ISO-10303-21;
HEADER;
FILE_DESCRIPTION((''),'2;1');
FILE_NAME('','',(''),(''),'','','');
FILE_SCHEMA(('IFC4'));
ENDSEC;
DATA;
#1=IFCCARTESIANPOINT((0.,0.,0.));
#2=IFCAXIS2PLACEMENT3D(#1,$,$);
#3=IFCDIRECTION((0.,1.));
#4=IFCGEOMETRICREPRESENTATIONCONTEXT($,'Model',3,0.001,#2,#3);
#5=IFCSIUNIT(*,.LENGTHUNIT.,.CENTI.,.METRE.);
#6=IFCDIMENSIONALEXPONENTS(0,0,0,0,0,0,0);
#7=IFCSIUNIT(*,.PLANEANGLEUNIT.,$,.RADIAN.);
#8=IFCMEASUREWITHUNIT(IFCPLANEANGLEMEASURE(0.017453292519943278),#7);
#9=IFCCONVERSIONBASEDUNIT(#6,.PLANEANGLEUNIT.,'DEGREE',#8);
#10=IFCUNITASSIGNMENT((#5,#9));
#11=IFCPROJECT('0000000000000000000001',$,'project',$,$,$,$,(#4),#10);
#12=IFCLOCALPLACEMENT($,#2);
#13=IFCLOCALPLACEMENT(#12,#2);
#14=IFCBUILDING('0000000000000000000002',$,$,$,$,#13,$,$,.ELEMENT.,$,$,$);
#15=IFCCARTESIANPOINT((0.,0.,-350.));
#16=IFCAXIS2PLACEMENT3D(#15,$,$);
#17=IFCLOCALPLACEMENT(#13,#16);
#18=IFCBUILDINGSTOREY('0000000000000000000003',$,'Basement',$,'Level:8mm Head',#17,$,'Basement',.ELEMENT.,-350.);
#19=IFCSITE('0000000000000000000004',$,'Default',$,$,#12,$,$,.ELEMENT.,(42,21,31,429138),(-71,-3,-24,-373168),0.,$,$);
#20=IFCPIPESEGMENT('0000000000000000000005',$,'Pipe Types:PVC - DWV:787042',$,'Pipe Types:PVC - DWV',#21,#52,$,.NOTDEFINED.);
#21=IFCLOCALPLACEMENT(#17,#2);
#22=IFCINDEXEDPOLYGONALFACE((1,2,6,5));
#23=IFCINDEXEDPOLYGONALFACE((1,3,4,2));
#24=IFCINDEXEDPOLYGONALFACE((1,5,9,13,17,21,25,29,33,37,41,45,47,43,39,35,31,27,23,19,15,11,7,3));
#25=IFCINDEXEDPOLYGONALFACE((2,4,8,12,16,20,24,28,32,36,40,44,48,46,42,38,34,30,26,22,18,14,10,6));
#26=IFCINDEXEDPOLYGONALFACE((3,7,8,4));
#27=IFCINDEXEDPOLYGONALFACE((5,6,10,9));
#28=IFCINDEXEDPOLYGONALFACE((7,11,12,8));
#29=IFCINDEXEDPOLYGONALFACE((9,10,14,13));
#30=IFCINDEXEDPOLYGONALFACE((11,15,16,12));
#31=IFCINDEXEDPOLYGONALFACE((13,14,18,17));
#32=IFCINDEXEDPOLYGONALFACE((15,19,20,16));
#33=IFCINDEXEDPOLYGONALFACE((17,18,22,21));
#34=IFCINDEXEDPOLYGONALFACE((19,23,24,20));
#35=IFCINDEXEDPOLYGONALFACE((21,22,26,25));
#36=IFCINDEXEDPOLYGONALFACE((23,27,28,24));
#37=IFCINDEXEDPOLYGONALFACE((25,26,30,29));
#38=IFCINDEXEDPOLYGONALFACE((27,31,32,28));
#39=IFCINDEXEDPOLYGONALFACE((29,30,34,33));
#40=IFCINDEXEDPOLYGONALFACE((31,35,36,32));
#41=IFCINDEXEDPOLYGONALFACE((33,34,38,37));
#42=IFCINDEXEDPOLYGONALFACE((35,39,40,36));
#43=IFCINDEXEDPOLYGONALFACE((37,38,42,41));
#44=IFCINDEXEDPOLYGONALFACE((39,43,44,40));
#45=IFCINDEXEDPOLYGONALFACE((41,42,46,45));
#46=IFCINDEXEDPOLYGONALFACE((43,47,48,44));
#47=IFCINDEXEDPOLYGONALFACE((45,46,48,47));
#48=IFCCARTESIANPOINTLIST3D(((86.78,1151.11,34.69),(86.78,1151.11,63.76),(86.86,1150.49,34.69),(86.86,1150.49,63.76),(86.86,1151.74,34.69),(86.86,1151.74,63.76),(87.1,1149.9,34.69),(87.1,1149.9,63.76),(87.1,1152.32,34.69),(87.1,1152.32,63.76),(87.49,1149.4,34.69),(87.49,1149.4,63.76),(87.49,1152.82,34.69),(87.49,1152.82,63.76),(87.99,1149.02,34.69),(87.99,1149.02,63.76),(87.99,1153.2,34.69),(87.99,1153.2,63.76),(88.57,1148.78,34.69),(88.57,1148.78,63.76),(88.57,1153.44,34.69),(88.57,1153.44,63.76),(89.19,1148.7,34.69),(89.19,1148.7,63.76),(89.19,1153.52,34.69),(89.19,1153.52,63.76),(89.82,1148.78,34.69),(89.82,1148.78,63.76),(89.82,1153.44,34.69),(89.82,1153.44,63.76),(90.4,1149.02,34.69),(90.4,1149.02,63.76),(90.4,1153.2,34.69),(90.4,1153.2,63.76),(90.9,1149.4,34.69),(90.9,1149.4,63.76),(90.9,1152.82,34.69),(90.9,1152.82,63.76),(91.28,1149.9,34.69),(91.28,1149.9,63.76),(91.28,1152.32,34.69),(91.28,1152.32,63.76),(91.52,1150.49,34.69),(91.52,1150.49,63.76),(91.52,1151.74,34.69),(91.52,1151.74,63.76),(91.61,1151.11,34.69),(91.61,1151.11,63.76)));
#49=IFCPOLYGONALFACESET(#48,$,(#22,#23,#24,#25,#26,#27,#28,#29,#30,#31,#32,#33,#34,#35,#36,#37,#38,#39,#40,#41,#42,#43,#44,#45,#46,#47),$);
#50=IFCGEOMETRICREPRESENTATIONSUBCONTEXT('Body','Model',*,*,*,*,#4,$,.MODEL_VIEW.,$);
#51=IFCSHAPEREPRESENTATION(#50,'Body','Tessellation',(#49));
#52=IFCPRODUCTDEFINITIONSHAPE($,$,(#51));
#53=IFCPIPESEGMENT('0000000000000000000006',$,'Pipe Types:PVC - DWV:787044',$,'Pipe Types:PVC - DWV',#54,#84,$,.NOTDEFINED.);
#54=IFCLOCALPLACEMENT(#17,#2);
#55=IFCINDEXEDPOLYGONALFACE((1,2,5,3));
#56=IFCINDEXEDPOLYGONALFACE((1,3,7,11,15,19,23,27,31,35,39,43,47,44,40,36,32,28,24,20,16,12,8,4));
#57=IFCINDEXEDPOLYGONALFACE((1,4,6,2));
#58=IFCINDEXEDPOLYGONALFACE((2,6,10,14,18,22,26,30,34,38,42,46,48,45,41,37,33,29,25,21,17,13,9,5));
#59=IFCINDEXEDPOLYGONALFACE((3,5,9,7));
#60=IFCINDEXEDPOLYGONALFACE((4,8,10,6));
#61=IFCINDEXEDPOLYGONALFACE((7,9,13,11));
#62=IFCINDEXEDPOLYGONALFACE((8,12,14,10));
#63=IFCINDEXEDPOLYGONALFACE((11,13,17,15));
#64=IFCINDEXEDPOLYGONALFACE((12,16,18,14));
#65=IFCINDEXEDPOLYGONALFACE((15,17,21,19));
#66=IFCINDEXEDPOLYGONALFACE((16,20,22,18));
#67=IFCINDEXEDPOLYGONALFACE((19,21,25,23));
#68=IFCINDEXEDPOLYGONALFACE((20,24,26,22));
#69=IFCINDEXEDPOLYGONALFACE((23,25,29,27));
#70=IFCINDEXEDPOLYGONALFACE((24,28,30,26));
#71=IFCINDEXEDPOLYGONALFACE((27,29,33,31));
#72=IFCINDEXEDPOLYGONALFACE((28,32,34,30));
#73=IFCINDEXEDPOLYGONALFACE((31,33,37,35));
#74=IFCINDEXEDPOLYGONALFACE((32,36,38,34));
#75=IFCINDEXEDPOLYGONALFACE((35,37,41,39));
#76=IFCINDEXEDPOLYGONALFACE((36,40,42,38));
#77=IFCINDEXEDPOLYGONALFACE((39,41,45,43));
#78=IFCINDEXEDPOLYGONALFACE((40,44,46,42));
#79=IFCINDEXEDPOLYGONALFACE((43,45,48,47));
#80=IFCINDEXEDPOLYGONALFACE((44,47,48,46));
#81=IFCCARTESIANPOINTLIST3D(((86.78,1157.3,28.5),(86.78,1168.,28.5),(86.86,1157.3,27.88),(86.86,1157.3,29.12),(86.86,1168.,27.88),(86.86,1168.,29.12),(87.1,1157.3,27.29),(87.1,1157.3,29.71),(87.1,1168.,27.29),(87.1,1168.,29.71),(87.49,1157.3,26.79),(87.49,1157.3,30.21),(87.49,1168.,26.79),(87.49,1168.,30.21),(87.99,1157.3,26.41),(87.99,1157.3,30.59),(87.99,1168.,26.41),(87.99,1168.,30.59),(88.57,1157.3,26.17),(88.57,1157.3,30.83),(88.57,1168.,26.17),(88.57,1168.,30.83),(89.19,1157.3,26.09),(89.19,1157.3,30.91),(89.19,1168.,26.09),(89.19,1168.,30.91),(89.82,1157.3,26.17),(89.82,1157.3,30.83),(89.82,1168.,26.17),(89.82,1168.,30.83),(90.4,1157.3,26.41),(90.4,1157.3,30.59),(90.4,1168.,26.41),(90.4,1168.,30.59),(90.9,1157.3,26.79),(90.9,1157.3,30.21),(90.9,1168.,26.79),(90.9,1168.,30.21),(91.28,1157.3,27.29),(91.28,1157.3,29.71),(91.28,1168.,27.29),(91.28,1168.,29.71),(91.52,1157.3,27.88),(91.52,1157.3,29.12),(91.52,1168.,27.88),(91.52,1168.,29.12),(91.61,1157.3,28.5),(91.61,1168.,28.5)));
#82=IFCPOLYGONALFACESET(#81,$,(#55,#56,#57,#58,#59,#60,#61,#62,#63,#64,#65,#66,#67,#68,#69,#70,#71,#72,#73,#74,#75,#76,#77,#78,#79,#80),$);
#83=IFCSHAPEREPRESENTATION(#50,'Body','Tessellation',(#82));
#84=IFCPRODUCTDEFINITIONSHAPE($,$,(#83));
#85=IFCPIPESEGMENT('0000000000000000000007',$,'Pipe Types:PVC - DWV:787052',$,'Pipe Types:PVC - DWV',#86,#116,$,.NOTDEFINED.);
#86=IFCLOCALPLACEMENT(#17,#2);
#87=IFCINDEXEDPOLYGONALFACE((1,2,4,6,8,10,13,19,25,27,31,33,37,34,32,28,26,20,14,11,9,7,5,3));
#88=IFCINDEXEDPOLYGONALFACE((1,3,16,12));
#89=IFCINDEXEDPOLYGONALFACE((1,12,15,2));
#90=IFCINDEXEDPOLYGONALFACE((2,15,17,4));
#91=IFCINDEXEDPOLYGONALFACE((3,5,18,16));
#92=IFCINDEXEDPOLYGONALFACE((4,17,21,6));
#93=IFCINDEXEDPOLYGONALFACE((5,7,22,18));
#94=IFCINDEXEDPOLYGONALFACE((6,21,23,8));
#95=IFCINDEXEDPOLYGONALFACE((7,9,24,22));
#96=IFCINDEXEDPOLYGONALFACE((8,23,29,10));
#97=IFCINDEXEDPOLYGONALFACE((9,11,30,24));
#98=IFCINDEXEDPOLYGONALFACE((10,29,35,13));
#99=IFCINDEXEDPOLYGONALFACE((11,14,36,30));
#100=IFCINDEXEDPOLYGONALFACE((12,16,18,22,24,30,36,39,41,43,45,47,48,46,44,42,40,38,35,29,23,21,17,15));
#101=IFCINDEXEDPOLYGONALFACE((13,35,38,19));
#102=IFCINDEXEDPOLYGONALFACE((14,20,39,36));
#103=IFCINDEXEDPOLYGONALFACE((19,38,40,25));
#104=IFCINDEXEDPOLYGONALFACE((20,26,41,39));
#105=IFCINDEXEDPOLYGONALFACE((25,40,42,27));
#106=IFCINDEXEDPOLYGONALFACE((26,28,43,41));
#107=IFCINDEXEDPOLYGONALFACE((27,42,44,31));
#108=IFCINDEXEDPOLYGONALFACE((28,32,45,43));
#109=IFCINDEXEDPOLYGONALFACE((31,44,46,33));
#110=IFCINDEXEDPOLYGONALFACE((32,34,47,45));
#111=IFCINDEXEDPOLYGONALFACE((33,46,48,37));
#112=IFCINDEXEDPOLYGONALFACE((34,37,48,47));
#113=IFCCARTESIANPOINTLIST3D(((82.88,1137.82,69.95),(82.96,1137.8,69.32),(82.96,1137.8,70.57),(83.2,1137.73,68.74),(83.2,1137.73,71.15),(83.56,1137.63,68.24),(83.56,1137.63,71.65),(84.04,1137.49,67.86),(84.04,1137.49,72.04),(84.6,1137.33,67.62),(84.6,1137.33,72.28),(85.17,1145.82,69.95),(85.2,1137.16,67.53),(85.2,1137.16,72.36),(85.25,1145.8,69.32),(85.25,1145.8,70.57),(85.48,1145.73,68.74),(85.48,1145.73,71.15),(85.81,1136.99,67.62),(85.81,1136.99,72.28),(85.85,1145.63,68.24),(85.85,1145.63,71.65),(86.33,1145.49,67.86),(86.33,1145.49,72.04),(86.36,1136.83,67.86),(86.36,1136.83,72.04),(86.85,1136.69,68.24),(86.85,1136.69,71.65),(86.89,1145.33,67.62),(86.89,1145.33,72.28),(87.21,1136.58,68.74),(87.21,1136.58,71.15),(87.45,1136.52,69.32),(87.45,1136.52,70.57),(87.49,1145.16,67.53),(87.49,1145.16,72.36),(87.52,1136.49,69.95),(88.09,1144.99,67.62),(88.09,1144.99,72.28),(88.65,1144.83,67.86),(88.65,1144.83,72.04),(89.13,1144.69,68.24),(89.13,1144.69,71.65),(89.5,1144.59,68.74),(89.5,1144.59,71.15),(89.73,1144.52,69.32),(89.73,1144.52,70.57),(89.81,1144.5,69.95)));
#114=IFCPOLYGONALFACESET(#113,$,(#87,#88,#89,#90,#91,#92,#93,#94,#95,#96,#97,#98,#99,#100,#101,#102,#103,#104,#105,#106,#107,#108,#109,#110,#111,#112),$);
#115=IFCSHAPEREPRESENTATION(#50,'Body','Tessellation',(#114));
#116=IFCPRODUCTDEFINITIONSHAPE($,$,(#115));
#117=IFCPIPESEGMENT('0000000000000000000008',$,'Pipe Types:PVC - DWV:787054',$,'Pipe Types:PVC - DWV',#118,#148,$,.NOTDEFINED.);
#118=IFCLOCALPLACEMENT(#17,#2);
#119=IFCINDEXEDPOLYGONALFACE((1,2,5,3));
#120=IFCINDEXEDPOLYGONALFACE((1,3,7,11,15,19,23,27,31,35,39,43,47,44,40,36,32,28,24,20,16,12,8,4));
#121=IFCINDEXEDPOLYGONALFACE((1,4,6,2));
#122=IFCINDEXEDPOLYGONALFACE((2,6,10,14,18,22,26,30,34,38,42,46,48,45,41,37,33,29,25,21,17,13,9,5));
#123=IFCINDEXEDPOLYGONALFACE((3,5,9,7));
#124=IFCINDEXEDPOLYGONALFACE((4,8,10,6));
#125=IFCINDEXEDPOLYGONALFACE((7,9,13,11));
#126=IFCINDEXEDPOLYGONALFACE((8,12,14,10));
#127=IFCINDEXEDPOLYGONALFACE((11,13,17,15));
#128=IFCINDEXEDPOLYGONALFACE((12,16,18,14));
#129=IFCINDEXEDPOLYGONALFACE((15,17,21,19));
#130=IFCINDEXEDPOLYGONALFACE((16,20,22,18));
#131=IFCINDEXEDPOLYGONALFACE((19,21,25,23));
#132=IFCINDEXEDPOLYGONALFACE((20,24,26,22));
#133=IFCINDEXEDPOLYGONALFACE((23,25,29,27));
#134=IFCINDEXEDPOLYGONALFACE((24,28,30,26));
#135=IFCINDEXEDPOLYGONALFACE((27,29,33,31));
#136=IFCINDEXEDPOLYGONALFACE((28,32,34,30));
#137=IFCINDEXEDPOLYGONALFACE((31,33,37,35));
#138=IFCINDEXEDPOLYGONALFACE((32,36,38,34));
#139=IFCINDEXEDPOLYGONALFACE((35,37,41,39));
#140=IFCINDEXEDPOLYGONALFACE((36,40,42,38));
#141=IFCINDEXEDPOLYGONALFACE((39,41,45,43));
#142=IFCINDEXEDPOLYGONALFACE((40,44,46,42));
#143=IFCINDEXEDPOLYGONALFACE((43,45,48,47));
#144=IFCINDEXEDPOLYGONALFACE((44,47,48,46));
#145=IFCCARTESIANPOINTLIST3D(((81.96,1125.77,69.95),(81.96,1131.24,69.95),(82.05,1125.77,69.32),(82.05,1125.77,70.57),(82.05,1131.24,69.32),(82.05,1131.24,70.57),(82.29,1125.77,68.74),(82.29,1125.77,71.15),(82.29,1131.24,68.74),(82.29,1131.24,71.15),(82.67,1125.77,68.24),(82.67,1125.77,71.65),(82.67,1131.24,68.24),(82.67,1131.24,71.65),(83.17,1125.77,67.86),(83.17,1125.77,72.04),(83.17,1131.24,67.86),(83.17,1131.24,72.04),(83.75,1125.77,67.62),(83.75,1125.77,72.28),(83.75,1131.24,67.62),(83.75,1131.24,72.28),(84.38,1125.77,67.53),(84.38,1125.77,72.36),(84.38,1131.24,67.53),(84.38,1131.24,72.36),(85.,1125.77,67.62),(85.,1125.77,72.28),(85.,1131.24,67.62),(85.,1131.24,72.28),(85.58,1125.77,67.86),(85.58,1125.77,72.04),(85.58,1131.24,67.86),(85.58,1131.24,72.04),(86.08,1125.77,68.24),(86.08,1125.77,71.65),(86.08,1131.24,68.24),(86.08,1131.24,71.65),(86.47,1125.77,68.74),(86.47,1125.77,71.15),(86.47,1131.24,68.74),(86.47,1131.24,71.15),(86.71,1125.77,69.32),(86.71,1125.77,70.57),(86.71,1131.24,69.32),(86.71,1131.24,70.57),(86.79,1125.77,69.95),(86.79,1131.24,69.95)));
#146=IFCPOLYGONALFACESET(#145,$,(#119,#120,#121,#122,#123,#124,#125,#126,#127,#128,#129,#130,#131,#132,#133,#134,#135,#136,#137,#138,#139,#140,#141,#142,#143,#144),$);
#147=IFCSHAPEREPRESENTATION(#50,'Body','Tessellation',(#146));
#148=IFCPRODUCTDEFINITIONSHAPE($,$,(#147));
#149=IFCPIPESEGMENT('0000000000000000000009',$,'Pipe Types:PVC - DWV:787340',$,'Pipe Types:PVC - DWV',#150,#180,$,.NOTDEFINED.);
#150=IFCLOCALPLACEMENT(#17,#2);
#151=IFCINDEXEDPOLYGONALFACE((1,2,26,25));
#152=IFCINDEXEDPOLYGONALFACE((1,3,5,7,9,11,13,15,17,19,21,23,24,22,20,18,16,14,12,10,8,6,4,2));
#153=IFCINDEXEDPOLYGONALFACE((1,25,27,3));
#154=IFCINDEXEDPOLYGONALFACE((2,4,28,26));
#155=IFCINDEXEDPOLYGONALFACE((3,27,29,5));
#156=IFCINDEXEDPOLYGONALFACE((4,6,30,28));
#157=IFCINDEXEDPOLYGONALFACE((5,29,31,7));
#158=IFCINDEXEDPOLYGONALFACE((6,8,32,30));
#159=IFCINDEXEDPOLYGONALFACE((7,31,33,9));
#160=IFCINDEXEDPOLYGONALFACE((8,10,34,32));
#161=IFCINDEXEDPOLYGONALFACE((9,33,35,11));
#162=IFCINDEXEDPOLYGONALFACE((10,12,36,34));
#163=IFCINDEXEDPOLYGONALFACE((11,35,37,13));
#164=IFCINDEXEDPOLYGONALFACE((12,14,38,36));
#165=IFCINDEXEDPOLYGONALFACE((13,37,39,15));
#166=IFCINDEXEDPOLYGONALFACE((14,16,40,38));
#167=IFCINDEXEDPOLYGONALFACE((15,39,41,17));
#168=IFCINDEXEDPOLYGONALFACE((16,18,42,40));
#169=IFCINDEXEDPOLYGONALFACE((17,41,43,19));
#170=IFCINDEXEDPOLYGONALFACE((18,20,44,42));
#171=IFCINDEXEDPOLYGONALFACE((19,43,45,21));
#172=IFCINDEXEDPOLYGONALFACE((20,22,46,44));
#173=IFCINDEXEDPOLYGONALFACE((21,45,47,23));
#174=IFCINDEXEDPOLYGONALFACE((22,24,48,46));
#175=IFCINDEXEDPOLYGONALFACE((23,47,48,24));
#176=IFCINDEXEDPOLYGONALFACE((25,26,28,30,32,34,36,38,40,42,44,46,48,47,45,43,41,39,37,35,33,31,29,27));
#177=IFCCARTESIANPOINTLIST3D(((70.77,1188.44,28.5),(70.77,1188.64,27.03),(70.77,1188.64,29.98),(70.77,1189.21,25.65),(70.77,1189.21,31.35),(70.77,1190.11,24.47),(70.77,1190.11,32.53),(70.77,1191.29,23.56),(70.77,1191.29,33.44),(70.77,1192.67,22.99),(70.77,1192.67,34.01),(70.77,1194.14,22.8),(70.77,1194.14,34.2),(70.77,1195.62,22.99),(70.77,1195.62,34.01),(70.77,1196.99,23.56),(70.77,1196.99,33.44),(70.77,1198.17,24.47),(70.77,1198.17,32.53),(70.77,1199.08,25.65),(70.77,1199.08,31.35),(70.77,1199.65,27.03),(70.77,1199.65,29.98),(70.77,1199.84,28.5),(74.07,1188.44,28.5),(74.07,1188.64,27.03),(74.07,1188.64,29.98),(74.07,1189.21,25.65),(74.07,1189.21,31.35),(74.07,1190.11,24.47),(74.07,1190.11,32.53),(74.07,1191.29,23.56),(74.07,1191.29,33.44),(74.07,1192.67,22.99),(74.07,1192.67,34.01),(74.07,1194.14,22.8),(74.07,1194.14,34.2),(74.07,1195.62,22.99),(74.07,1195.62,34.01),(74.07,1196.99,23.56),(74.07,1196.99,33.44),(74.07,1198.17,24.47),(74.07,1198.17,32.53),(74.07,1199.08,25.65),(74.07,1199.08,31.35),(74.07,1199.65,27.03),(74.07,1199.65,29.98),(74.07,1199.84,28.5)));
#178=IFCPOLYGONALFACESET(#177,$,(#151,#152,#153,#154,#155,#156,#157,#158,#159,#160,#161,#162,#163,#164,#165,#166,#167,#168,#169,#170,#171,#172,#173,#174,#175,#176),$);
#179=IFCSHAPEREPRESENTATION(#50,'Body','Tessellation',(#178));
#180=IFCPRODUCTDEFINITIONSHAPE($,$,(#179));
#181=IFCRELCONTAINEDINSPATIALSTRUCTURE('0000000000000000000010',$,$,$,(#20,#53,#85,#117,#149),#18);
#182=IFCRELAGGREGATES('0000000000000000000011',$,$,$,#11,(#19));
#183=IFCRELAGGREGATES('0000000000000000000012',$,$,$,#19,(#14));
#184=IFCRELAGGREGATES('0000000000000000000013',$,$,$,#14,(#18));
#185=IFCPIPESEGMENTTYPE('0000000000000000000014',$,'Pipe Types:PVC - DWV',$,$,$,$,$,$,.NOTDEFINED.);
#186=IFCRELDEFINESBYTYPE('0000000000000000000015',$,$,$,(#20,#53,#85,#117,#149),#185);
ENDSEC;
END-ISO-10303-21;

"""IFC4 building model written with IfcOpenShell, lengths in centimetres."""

from ifc_helpers import new_model, entity, si_unit, converted_unit, direction, frame, origin, place, context, subcontext, project, spatial, arc, indexed_curve, outline, extrude, type_object, element, save


model = new_model("IFC4")

# Units and contexts
model_context = context("Model", 3, precision=0.001, world=origin(), true_north=direction((0.0, 1.0)))
body_context = subcontext(model_context, "Body", "Model", "MODEL_VIEW")
ifc_project = project(units=[si_unit("LENGTHUNIT", "METRE", prefix="CENTI"), converted_unit("PLANEANGLEUNIT", "DEGREE", entity("IfcPlaneAngleMeasure", 0.017453292519943278), si_unit("PLANEANGLEUNIT", "RADIAN"), dimensions=[0, 0, 0, 0, 0, 0, 0])], contexts=[model_context])

# Site, building, storey
site_placement = place(None, origin())
site = spatial("IfcSite", under=ifc_project, at=site_placement, Name="Default", CompositionType="ELEMENT", RefLatitude=(42, 21, 31, 429138), RefLongitude=(-71, -3, -24, -373168), RefElevation=0.0)
building_placement = place(site_placement, origin())
building = spatial("IfcBuilding", under=site, at=building_placement, CompositionType="ELEMENT")
storey_placement = place(building_placement, frame((0.0, 0.0, -350.0)))
storey = spatial("IfcBuildingStorey", under=building, at=storey_placement, Name="Basement", ObjectType="Level:8mm Head", LongName="Basement", CompositionType="ELEMENT", Elevation=-350.0)

# Pipe segments
pipe_segment_type = type_object("IfcPipeSegmentType", Name="Pipe Types:PVC - DWV", PredefinedType="NOTDEFINED")
pipe_segment_1_placement = place(storey_placement, origin())
element("IfcPipeSegment", 1, at=pipe_segment_1_placement, inside=storey, type_object=pipe_segment_type, Name="Pipe Types:PVC - DWV:787042", ObjectType="Pipe Types:PVC - DWV", PredefinedType="NOTDEFINED", context=body_context, shape_type="SweptSolid", body=[
    extrude(outline(indexed_curve([(2.41, 0.0), (1.71, 1.71), (0.0, 2.41), (-1.71, 1.71), (-2.41, 0.0), (-1.71, -1.71), (0.0, -2.41), (1.71, -1.71)], segments=[arc(1, 2, 3), arc(3, 4, 5), arc(5, 6, 7), arc(7, 8, 1)], self_intersect=False)), frame((89.19, 1151.11, 34.69)), (0.0, 0.0, 1.0), 29.07),
])
pipe_segment_2_placement = place(storey_placement, origin())
element("IfcPipeSegment", 2, at=pipe_segment_2_placement, inside=storey, type_object=pipe_segment_type, Name="Pipe Types:PVC - DWV:787044", ObjectType="Pipe Types:PVC - DWV", PredefinedType="NOTDEFINED", context=body_context, shape_type="SweptSolid", body=[
    extrude(outline(indexed_curve([(2.41, 0.0), (1.71, 1.71), (0.0, 2.41), (-1.71, 1.71), (-2.41, 0.0), (-1.71, -1.71), (0.0, -2.41), (1.71, -1.71)], segments=[arc(1, 2, 3), arc(3, 4, 5), arc(5, 6, 7), arc(7, 8, 1)], self_intersect=False)), frame((89.19, 1157.3, 28.5), z_axis=(0.0, 1.0, 0.0), x_axis=(1.0, 0.0, 0.0)), (0.0, 0.0, 1.0), 10.7),
])
pipe_segment_3_placement = place(storey_placement, origin())
element("IfcPipeSegment", 3, at=pipe_segment_3_placement, inside=storey, type_object=pipe_segment_type, Name="Pipe Types:PVC - DWV:787052", ObjectType="Pipe Types:PVC - DWV", PredefinedType="NOTDEFINED", context=body_context, shape_type="SweptSolid", body=[
    extrude(outline(indexed_curve([(2.41, 0.0), (1.71, 1.71), (0.0, 2.41), (-1.71, 1.71), (-2.41, 0.0), (-1.71, -1.71), (0.0, -2.41), (1.71, -1.71)], segments=[arc(1, 2, 3), arc(3, 4, 5), arc(5, 6, 7), arc(7, 8, 1)], self_intersect=False)), frame((85.2, 1137.16, 69.95), z_axis=(0.274825, 0.961494, 0.0), x_axis=(0.961494, -0.274825, 0.0)), (0.0, 0.0, 1.0), 8.32),
])
pipe_segment_4_placement = place(storey_placement, origin())
element("IfcPipeSegment", 4, at=pipe_segment_4_placement, inside=storey, type_object=pipe_segment_type, Name="Pipe Types:PVC - DWV:787054", ObjectType="Pipe Types:PVC - DWV", PredefinedType="NOTDEFINED", context=body_context, shape_type="SweptSolid", body=[
    extrude(outline(indexed_curve([(2.41, 0.0), (1.71, 1.71), (0.0, 2.41), (-1.71, 1.71), (-2.41, 0.0), (-1.71, -1.71), (0.0, -2.41), (1.71, -1.71)], segments=[arc(1, 2, 3), arc(3, 4, 5), arc(5, 6, 7), arc(7, 8, 1)], self_intersect=False)), frame((84.38, 1125.77, 69.95), z_axis=(0.0, 1.0, 0.0), x_axis=(1.0, 0.0, 0.0)), (0.0, 0.0, 1.0), 5.48),
])
pipe_segment_5_placement = place(storey_placement, origin())
element("IfcPipeSegment", 5, at=pipe_segment_5_placement, inside=storey, type_object=pipe_segment_type, Name="Pipe Types:PVC - DWV:787340", ObjectType="Pipe Types:PVC - DWV", PredefinedType="NOTDEFINED", context=body_context, shape_type="SweptSolid", body=[
    extrude(outline(indexed_curve([(5.7, 0.0), (4.03, 4.03), (0.0, 5.7), (-4.03, 4.03), (-5.7, 0.0), (-4.03, -4.03), (0.0, -5.7), (4.03, -4.03)], segments=[arc(1, 2, 3), arc(3, 4, 5), arc(5, 6, 7), arc(7, 8, 1)], self_intersect=False)), frame((70.77, 1194.14, 28.5), z_axis=(1.0, 0.0, 0.0), x_axis=(0.0, -1.0, 0.0)), (0.0, 0.0, 1.0), 3.3),
])

save(model, "model.ifc")
